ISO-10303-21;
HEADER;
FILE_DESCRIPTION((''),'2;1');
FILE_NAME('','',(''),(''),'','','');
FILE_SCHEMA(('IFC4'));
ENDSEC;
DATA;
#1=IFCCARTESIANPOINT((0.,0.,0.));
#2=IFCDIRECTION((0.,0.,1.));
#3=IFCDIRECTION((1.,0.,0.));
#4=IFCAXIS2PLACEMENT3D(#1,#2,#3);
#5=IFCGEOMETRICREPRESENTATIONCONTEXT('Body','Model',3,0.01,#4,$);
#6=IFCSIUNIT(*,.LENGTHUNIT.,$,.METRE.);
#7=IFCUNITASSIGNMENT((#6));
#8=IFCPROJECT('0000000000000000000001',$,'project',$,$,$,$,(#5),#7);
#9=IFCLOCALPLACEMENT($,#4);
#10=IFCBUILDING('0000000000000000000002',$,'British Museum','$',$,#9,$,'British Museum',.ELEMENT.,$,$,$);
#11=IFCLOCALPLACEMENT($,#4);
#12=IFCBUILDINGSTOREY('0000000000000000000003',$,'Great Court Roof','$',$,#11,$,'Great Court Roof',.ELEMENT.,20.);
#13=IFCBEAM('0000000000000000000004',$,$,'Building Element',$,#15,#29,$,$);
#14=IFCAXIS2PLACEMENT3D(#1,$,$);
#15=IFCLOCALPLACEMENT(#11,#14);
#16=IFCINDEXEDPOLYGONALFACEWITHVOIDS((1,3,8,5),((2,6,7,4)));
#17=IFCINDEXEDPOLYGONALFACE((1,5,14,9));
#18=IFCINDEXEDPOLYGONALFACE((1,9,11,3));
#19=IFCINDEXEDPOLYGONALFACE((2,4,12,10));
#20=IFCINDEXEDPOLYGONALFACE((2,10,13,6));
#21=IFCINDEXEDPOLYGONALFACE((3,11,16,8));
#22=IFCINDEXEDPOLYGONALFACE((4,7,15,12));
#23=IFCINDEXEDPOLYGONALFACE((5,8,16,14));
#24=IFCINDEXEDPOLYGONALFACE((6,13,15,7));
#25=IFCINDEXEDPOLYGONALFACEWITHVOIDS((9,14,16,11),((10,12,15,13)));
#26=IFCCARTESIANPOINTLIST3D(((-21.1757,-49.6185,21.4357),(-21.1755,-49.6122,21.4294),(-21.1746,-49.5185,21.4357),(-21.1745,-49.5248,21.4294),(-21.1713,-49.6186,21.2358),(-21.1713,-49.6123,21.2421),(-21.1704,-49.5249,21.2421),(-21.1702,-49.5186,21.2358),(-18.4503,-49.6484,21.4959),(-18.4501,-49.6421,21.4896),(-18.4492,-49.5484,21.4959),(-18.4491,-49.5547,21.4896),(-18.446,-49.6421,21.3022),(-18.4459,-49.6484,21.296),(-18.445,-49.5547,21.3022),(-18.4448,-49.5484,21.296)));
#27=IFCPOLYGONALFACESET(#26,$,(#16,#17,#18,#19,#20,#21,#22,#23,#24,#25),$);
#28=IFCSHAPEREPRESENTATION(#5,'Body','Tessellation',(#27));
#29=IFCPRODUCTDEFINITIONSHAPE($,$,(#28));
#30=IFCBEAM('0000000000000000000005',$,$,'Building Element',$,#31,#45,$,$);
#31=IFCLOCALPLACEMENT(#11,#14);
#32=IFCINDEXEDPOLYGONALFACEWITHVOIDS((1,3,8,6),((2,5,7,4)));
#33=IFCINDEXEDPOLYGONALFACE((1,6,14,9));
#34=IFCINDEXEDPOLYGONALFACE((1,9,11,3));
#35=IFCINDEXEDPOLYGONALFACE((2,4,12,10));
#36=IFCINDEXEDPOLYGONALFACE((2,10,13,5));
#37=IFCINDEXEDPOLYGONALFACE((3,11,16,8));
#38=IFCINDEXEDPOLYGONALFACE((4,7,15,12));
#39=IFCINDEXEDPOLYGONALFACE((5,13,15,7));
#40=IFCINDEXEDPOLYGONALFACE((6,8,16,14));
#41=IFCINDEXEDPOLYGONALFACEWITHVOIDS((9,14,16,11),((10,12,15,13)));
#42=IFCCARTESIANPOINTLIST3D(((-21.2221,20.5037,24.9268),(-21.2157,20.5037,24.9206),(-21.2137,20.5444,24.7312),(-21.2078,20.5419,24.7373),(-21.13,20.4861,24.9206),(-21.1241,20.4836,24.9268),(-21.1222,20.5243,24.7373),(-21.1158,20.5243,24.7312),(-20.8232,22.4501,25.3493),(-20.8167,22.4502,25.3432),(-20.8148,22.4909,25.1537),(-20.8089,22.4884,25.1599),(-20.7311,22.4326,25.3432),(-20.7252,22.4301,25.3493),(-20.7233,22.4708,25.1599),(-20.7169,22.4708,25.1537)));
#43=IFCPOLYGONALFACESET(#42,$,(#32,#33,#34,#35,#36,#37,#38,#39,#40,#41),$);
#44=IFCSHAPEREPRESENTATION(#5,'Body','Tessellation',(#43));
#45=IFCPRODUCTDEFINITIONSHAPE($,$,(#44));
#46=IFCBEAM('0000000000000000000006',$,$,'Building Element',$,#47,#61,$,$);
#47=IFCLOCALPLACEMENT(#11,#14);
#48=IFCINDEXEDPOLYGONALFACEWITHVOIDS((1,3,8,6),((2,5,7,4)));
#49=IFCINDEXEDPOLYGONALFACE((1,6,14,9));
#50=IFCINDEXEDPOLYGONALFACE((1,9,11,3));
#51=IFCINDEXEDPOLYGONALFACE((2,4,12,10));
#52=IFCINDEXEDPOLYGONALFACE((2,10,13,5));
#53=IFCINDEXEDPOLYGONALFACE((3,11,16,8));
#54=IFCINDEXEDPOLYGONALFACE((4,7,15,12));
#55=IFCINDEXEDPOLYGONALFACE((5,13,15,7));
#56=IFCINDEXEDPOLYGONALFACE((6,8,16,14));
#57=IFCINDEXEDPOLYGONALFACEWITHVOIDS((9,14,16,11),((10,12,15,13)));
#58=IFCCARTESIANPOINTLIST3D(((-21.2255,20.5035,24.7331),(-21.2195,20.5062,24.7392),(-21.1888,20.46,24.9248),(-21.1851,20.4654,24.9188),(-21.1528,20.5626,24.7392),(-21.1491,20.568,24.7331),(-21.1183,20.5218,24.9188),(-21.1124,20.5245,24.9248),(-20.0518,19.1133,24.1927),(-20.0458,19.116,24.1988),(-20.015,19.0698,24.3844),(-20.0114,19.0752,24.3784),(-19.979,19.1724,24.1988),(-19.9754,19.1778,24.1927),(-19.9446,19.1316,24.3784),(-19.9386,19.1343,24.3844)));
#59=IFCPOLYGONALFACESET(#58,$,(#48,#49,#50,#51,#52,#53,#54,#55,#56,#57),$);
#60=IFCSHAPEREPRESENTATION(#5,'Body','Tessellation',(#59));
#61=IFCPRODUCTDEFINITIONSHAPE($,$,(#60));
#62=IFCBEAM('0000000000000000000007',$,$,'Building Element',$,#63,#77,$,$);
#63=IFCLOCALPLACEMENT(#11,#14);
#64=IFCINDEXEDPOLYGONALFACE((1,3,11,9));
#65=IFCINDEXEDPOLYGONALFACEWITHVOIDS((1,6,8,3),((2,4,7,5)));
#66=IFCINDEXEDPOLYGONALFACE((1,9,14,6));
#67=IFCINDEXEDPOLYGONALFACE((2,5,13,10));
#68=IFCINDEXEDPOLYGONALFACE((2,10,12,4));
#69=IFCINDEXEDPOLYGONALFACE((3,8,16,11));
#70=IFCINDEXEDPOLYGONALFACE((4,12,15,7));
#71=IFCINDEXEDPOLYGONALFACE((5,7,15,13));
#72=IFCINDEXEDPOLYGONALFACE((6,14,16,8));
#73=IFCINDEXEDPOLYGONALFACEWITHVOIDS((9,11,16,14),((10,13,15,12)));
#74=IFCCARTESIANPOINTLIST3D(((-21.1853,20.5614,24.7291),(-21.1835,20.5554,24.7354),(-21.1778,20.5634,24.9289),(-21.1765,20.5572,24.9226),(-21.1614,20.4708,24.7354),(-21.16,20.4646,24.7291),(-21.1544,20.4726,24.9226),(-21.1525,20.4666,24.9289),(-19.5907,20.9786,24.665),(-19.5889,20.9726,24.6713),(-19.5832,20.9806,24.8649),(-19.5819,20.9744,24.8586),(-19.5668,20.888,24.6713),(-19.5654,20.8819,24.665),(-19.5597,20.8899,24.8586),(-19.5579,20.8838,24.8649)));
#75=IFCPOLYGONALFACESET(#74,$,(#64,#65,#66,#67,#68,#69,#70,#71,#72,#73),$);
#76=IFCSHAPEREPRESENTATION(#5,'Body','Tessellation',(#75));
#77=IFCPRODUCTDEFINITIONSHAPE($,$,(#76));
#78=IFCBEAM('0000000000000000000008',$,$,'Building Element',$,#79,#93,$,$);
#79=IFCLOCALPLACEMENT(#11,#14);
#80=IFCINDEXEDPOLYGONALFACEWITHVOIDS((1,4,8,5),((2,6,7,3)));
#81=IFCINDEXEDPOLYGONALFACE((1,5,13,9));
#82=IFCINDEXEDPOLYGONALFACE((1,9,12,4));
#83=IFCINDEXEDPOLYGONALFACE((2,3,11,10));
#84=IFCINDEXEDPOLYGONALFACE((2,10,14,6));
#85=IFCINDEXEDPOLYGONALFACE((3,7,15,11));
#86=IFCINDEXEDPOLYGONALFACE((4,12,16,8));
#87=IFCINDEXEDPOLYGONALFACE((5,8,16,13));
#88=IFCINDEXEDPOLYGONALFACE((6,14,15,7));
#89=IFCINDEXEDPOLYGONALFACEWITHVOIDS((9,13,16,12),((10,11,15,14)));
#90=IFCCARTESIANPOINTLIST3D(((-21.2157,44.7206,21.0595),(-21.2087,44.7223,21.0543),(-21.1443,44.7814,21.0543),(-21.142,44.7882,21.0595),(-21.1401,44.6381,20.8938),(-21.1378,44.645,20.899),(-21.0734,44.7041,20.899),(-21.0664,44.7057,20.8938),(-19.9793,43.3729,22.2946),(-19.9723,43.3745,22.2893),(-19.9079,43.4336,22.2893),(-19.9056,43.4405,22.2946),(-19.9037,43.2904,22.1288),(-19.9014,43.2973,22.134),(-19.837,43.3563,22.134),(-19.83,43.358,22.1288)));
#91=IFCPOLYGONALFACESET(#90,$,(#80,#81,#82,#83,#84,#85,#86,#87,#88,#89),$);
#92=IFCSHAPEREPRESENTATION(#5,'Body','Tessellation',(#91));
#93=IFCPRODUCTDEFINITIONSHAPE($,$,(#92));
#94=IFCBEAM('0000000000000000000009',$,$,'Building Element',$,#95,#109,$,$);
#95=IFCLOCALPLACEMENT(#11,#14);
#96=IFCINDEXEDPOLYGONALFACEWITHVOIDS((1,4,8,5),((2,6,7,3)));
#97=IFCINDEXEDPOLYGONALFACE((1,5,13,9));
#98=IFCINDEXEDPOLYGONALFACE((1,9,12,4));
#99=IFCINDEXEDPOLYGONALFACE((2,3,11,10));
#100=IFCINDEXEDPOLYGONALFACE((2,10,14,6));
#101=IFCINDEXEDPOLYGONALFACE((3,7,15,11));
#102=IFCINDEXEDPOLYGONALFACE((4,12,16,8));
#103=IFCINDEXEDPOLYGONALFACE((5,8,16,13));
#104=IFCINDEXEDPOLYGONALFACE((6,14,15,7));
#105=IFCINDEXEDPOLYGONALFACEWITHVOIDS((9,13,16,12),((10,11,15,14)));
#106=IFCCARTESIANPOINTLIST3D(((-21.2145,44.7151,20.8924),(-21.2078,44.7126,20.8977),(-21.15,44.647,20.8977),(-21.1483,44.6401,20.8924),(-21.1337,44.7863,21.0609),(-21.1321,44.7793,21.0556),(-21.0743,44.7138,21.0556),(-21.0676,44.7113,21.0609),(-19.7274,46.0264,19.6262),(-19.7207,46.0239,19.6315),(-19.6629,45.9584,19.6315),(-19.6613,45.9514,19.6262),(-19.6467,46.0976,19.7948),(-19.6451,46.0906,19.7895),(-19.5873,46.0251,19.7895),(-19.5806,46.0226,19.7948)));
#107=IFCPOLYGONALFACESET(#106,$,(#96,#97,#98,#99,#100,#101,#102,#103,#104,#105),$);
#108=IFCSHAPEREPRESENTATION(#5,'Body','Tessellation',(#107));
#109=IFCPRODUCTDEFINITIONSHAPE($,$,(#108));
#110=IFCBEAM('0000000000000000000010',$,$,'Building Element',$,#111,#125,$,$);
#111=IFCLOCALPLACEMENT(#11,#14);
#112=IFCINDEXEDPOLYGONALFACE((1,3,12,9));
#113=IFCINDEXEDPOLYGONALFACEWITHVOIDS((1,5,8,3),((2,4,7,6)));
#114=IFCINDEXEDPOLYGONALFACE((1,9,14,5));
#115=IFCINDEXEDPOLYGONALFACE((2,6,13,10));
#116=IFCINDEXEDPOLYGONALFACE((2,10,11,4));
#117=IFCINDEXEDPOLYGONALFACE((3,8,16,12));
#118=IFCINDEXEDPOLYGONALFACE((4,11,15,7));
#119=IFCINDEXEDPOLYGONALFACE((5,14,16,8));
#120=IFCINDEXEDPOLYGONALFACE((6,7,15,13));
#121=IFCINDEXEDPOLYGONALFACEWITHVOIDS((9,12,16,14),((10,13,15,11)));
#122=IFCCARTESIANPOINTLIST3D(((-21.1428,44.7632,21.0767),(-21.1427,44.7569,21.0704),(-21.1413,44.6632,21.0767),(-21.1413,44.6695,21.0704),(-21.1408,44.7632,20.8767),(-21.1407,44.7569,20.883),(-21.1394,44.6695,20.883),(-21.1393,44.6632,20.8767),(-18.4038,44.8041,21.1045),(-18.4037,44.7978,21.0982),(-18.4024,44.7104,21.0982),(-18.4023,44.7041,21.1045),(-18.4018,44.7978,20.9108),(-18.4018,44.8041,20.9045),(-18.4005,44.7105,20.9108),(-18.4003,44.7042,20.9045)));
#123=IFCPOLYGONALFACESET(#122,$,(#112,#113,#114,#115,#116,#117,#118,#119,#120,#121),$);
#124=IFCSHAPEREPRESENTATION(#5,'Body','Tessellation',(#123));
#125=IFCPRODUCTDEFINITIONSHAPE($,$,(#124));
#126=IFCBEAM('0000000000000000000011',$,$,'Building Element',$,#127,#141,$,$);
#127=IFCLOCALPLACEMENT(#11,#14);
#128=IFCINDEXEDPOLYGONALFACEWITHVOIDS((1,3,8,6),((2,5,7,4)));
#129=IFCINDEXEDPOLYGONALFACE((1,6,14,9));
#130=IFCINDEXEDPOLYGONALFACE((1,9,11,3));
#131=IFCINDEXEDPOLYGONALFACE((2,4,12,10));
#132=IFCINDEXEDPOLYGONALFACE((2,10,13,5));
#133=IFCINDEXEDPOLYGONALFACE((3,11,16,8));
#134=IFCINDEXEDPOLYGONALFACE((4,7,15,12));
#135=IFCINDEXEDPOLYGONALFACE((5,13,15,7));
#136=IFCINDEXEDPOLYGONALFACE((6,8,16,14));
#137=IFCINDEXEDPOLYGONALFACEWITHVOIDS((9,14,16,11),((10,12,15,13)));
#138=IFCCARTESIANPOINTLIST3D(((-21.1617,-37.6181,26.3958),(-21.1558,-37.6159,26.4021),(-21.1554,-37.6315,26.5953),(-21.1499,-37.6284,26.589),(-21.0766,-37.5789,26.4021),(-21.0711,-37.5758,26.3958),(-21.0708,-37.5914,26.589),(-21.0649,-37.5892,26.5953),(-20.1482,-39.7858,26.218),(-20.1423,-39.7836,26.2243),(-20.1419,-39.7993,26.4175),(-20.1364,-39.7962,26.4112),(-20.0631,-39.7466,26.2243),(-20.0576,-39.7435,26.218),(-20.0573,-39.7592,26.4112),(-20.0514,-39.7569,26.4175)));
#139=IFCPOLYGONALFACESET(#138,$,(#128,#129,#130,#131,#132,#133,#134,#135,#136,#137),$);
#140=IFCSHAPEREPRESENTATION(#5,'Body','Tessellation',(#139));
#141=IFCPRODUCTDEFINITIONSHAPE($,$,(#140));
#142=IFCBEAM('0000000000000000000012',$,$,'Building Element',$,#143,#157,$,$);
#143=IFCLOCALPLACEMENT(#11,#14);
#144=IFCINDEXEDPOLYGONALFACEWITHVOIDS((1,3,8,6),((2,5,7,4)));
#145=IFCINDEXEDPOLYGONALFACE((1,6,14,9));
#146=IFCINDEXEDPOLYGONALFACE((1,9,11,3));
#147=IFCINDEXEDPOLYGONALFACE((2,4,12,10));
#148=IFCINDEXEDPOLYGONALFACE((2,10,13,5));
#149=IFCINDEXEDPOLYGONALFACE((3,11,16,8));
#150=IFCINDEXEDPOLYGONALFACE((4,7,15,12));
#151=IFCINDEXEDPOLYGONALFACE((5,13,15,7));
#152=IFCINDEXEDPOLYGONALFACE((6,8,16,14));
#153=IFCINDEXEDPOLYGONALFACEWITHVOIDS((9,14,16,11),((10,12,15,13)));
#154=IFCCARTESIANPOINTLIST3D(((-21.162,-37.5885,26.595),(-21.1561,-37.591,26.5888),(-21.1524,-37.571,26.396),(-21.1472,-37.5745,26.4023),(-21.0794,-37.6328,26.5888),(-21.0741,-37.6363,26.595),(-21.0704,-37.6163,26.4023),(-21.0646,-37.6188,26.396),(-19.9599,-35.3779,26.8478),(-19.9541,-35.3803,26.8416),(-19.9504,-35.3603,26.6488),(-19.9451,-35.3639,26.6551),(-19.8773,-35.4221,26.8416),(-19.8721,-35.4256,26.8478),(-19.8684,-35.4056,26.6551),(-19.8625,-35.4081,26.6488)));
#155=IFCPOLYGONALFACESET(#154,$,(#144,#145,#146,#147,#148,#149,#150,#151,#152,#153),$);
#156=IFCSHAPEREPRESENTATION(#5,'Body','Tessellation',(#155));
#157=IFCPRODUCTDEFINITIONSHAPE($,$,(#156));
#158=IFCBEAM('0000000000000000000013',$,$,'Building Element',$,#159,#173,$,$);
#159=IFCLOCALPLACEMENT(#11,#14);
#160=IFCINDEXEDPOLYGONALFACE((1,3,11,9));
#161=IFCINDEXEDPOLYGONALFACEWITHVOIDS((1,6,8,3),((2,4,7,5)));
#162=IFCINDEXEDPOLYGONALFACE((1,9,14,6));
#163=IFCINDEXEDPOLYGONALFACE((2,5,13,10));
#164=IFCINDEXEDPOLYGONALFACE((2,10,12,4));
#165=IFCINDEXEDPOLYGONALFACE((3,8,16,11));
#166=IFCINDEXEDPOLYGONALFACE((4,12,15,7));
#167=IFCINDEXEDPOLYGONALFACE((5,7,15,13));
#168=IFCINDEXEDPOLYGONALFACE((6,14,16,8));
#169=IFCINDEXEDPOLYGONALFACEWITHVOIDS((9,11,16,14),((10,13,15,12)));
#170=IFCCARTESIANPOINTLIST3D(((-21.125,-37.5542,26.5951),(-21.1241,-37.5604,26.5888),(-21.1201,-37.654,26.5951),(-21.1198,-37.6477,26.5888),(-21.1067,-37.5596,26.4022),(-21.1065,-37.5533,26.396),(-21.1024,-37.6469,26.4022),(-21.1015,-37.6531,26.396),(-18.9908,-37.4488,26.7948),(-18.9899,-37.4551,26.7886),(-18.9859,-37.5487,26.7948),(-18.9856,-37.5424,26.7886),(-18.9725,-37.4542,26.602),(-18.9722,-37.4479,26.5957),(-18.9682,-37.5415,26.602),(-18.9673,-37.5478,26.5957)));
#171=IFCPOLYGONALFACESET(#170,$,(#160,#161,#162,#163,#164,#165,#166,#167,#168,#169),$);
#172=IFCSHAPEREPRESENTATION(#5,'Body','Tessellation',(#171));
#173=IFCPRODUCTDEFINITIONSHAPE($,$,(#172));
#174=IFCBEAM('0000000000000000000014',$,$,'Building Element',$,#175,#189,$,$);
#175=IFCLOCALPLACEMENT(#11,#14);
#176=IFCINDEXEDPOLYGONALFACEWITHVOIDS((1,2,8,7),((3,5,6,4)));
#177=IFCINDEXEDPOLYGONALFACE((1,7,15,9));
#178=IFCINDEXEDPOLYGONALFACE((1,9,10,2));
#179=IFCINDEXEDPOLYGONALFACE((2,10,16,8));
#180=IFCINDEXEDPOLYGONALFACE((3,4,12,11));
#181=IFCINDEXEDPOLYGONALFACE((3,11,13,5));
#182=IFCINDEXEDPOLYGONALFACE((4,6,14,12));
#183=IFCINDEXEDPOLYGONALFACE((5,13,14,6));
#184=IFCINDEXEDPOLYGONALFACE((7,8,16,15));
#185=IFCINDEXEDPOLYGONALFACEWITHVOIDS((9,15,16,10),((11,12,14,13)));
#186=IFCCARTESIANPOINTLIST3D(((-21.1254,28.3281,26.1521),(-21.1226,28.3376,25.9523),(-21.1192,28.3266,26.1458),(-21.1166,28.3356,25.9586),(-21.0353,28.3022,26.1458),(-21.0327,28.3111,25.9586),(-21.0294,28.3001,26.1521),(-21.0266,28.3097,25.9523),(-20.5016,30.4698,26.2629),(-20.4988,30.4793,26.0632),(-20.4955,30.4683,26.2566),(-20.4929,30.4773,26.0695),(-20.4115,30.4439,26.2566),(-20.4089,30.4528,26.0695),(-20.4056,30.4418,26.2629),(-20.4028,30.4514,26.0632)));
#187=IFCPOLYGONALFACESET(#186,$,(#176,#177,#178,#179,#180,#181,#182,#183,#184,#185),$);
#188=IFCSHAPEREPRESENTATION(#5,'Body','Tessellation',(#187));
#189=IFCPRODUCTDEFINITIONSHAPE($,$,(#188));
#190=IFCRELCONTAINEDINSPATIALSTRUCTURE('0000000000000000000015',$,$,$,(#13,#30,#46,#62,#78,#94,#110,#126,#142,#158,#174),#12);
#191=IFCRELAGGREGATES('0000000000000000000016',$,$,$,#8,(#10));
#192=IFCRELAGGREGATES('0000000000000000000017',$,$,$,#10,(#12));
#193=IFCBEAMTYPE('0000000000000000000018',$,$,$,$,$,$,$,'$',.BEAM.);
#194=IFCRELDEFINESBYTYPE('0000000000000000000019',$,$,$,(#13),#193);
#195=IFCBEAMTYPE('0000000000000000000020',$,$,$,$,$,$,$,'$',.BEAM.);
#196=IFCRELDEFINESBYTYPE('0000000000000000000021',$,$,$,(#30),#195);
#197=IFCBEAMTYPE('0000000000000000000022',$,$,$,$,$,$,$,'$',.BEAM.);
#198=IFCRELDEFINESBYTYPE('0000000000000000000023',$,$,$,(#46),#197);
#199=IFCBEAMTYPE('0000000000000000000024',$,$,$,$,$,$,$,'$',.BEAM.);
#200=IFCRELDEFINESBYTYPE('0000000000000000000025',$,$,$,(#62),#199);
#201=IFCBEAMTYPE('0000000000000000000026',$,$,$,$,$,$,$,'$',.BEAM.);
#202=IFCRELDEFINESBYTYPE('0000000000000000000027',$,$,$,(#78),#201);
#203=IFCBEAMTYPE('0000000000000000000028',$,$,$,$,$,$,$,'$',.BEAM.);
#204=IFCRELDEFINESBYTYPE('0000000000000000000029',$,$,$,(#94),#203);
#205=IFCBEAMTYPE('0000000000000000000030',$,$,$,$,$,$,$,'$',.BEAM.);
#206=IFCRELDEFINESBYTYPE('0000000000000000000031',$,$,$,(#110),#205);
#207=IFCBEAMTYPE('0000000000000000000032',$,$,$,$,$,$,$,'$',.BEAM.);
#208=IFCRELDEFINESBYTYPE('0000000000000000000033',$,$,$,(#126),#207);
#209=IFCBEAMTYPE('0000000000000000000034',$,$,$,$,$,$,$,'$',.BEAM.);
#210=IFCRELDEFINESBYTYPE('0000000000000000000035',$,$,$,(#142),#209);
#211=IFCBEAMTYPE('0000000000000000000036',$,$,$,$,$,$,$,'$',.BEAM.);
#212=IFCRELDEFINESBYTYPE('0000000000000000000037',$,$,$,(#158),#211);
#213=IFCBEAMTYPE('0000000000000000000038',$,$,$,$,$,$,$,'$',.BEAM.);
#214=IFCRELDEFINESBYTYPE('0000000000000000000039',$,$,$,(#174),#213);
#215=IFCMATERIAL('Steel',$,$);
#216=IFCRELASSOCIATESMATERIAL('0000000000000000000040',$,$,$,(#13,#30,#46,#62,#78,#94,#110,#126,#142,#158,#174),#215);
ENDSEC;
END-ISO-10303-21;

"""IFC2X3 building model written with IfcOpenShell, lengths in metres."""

from ifc_helpers import new_model, si_unit, frame, origin_with_axes, origin_2d, place, context, project, spatial, hollow_rectangle, extrude, material, type_object, element, save


model = new_model("IFC2X3")

# Units and contexts
model_context = context("Model", 3, precision=0.01, world=origin_with_axes(), identifier="Body")
ifc_project = project(units=[si_unit("LENGTHUNIT", "METRE")], contexts=[model_context])

# Building, storey
building_placement = place(None, origin_with_axes())
building = spatial("IfcBuilding", under=ifc_project, at=building_placement, Name="British Museum", Description="$", LongName="British Museum", CompositionType="ELEMENT")
storey_placement = place(None, origin_with_axes())
storey = spatial("IfcBuildingStorey", under=building, at=storey_placement, Name="Great Court Roof", Description="$", LongName="Great Court Roof", CompositionType="ELEMENT", Elevation=20.0)

# Beams
ifc_material = material(Name="Steel")
beam_type_1 = type_object("IfcBeamType", ElementType="$", PredefinedType="BEAM")
beam_1_placement = place(None, origin_with_axes())
element("IfcBeam", 1, at=beam_1_placement, inside=storey, type_object=beam_type_1, material=ifc_material, Description="Building Element", context=model_context, shape_type="SweptSolid", body=[
    extrude(hollow_rectangle(XDim=0.1, YDim=0.2, WallThickness=0.0063, InnerFilletRadius=-0.0063, OuterFilletRadius=0.0, at=origin_2d()), frame((-21.1729, -49.5685, 21.3358), z_axis=(0.999697, -0.010944, 0.022069), x_axis=(0.010946, 0.99994, 0.0)), (0.0, 0.0, 1.0), 2.7262),
])
beam_type_2 = type_object("IfcBeamType", ElementType="$", PredefinedType="BEAM")
beam_2_placement = place(None, origin_with_axes())
element("IfcBeam", 2, at=beam_2_placement, inside=storey, type_object=beam_type_2, material=ifc_material, Description="Building Element", context=model_context, shape_type="SweptSolid", body=[
    extrude(hollow_rectangle(XDim=0.1, YDim=0.2, WallThickness=0.0063, InnerFilletRadius=-0.0063, OuterFilletRadius=0.0, at=origin_2d()), frame((-21.1689, 20.514, 24.829), z_axis=(0.196376, 0.958212, 0.208004), x_axis=(-0.979639, 0.200767, 0.0)), (0.0, 0.0, 1.0), 2.0314),
])
beam_type_3 = type_object("IfcBeamType", ElementType="$", PredefinedType="BEAM")
beam_3_placement = place(None, origin_with_axes())
element("IfcBeam", 3, at=beam_3_placement, inside=storey, type_object=beam_type_3, material=ifc_material, Description="Building Element", context=model_context, shape_type="SweptSolid", body=[
    extrude(hollow_rectangle(XDim=0.1, YDim=0.2, WallThickness=0.0063, InnerFilletRadius=-0.0063, OuterFilletRadius=0.0, at=origin_2d()), frame((-21.1689, 20.514, 24.829), z_axis=(0.618409, -0.732461, -0.28473), x_axis=(0.764088, 0.645112, 0.0)), (0.0, 0.0, 1.0), 1.898),
])
beam_type_4 = type_object("IfcBeamType", ElementType="$", PredefinedType="BEAM")
beam_4_placement = place(None, origin_with_axes())
element("IfcBeam", 4, at=beam_4_placement, inside=storey, type_object=beam_type_4, material=ifc_material, Description="Building Element", context=model_context, shape_type="SweptSolid", body=[
    extrude(hollow_rectangle(XDim=0.1, YDim=0.2, WallThickness=0.0063, InnerFilletRadius=-0.0063, OuterFilletRadius=0.0, at=origin_2d()), frame((-21.1689, 20.514, 24.829), z_axis=(0.966707, 0.252926, -0.038815), x_axis=(-0.253117, 0.967436, 0.0)), (0.0, 0.0, 1.0), 1.6495),
])
beam_type_5 = type_object("IfcBeamType", ElementType="$", PredefinedType="BEAM")
beam_5_placement = place(None, origin_with_axes())
element("IfcBeam", 5, at=beam_5_placement, inside=storey, type_object=beam_type_5, material=ifc_material, Description="Building Element", context=model_context, shape_type="SweptSolid", body=[
    extrude(hollow_rectangle(XDim=0.1, YDim=0.2, WallThickness=0.0063, InnerFilletRadius=-0.0063, OuterFilletRadius=0.0, at=origin_2d()), frame((-21.141, 44.7132, 20.9767), z_axis=(0.560245, -0.610694, 0.559623), x_axis=(0.736888, 0.676015, 0.0)), (0.0, 0.0, 1.0), 2.2069),
])
beam_type_6 = type_object("IfcBeamType", ElementType="$", PredefinedType="BEAM")
beam_6_placement = place(None, origin_with_axes())
element("IfcBeam", 6, at=beam_6_placement, inside=storey, type_object=beam_type_6, material=ifc_material, Description="Building Element", context=model_context, shape_type="SweptSolid", body=[
    extrude(hollow_rectangle(XDim=0.1, YDim=0.2, WallThickness=0.0063, InnerFilletRadius=-0.0063, OuterFilletRadius=0.0, at=origin_2d()), frame((-21.141, 44.7132, 20.9767), z_axis=(0.632129, 0.557428, -0.538226), x_axis=(-0.6614, 0.750033, 0.0)), (0.0, 0.0, 1.0), 2.3524),
])
beam_type_7 = type_object("IfcBeamType", ElementType="$", PredefinedType="BEAM")
beam_7_placement = place(None, origin_with_axes())
element("IfcBeam", 7, at=beam_7_placement, inside=storey, type_object=beam_type_7, material=ifc_material, Description="Building Element", context=model_context, shape_type="SweptSolid", body=[
    extrude(hollow_rectangle(XDim=0.1, YDim=0.2, WallThickness=0.0063, InnerFilletRadius=-0.0063, OuterFilletRadius=0.0, at=origin_2d()), frame((-21.141, 44.7132, 20.9767), z_axis=(0.999837, 0.01495, 0.010172), x_axis=(-0.014951, 0.999888, 0.0)), (0.0, 0.0, 1.0), 2.7394),
])
beam_type_8 = type_object("IfcBeamType", ElementType="$", PredefinedType="BEAM")
beam_8_placement = place(None, origin_with_axes())
element("IfcBeam", 8, at=beam_8_placement, inside=storey, type_object=beam_type_8, material=ifc_material, Description="Building Element", context=model_context, shape_type="SweptSolid", body=[
    extrude(hollow_rectangle(XDim=0.1, YDim=0.2, WallThickness=0.0063, InnerFilletRadius=-0.0063, OuterFilletRadius=0.0, at=origin_2d()), frame((-21.1133, -37.6036, 26.4955), z_axis=(0.422372, -0.903389, -0.074102), x_axis=(0.905879, 0.423536, 0.0)), (0.0, 0.0, 1.0), 2.3995),
])
beam_type_9 = type_object("IfcBeamType", ElementType="$", PredefinedType="BEAM")
beam_9_placement = place(None, origin_with_axes())
element("IfcBeam", 9, at=beam_9_placement, inside=storey, type_object=beam_type_9, material=ifc_material, Description="Building Element", context=model_context, shape_type="SweptSolid", body=[
    extrude(hollow_rectangle(XDim=0.1, YDim=0.2, WallThickness=0.0063, InnerFilletRadius=-0.0063, OuterFilletRadius=0.0, at=origin_2d()), frame((-21.1133, -37.6036, 26.4955), z_axis=(0.475309, 0.874122, 0.099957), x_axis=(-0.878522, 0.477702, 0.0)), (0.0, 0.0, 1.0), 2.529),
])
beam_type_10 = type_object("IfcBeamType", ElementType="$", PredefinedType="BEAM")
beam_10_placement = place(None, origin_with_axes())
element("IfcBeam", 10, at=beam_10_placement, inside=storey, type_object=beam_type_10, material=ifc_material, Description="Building Element", context=model_context, shape_type="SweptSolid", body=[
    extrude(hollow_rectangle(XDim=0.1, YDim=0.2, WallThickness=0.0063, InnerFilletRadius=-0.0063, OuterFilletRadius=0.0, at=origin_2d()), frame((-21.1133, -37.6036, 26.4955), z_axis=(0.99445, 0.049086, 0.093058), x_axis=(-0.0493, 0.998784, 0.0)), (0.0, 0.0, 1.0), 2.1462),
])
beam_type_11 = type_object("IfcBeamType", ElementType="$", PredefinedType="BEAM")
beam_11_placement = place(None, origin_with_axes())
element("IfcBeam", 11, at=beam_11_placement, inside=storey, type_object=beam_type_11, material=ifc_material, Description="Building Element", context=model_context, shape_type="SweptSolid", body=[
    extrude(hollow_rectangle(XDim=0.1, YDim=0.2, WallThickness=0.0063, InnerFilletRadius=-0.0063, OuterFilletRadius=0.0, at=origin_2d()), frame((-21.076, 28.3189, 26.0522), z_axis=(0.279292, 0.958922, 0.049637), x_axis=(-0.960106, 0.279636, 0.0)), (0.0, 0.0, 1.0), 2.2335),
])

save(model, "model.ifc")
